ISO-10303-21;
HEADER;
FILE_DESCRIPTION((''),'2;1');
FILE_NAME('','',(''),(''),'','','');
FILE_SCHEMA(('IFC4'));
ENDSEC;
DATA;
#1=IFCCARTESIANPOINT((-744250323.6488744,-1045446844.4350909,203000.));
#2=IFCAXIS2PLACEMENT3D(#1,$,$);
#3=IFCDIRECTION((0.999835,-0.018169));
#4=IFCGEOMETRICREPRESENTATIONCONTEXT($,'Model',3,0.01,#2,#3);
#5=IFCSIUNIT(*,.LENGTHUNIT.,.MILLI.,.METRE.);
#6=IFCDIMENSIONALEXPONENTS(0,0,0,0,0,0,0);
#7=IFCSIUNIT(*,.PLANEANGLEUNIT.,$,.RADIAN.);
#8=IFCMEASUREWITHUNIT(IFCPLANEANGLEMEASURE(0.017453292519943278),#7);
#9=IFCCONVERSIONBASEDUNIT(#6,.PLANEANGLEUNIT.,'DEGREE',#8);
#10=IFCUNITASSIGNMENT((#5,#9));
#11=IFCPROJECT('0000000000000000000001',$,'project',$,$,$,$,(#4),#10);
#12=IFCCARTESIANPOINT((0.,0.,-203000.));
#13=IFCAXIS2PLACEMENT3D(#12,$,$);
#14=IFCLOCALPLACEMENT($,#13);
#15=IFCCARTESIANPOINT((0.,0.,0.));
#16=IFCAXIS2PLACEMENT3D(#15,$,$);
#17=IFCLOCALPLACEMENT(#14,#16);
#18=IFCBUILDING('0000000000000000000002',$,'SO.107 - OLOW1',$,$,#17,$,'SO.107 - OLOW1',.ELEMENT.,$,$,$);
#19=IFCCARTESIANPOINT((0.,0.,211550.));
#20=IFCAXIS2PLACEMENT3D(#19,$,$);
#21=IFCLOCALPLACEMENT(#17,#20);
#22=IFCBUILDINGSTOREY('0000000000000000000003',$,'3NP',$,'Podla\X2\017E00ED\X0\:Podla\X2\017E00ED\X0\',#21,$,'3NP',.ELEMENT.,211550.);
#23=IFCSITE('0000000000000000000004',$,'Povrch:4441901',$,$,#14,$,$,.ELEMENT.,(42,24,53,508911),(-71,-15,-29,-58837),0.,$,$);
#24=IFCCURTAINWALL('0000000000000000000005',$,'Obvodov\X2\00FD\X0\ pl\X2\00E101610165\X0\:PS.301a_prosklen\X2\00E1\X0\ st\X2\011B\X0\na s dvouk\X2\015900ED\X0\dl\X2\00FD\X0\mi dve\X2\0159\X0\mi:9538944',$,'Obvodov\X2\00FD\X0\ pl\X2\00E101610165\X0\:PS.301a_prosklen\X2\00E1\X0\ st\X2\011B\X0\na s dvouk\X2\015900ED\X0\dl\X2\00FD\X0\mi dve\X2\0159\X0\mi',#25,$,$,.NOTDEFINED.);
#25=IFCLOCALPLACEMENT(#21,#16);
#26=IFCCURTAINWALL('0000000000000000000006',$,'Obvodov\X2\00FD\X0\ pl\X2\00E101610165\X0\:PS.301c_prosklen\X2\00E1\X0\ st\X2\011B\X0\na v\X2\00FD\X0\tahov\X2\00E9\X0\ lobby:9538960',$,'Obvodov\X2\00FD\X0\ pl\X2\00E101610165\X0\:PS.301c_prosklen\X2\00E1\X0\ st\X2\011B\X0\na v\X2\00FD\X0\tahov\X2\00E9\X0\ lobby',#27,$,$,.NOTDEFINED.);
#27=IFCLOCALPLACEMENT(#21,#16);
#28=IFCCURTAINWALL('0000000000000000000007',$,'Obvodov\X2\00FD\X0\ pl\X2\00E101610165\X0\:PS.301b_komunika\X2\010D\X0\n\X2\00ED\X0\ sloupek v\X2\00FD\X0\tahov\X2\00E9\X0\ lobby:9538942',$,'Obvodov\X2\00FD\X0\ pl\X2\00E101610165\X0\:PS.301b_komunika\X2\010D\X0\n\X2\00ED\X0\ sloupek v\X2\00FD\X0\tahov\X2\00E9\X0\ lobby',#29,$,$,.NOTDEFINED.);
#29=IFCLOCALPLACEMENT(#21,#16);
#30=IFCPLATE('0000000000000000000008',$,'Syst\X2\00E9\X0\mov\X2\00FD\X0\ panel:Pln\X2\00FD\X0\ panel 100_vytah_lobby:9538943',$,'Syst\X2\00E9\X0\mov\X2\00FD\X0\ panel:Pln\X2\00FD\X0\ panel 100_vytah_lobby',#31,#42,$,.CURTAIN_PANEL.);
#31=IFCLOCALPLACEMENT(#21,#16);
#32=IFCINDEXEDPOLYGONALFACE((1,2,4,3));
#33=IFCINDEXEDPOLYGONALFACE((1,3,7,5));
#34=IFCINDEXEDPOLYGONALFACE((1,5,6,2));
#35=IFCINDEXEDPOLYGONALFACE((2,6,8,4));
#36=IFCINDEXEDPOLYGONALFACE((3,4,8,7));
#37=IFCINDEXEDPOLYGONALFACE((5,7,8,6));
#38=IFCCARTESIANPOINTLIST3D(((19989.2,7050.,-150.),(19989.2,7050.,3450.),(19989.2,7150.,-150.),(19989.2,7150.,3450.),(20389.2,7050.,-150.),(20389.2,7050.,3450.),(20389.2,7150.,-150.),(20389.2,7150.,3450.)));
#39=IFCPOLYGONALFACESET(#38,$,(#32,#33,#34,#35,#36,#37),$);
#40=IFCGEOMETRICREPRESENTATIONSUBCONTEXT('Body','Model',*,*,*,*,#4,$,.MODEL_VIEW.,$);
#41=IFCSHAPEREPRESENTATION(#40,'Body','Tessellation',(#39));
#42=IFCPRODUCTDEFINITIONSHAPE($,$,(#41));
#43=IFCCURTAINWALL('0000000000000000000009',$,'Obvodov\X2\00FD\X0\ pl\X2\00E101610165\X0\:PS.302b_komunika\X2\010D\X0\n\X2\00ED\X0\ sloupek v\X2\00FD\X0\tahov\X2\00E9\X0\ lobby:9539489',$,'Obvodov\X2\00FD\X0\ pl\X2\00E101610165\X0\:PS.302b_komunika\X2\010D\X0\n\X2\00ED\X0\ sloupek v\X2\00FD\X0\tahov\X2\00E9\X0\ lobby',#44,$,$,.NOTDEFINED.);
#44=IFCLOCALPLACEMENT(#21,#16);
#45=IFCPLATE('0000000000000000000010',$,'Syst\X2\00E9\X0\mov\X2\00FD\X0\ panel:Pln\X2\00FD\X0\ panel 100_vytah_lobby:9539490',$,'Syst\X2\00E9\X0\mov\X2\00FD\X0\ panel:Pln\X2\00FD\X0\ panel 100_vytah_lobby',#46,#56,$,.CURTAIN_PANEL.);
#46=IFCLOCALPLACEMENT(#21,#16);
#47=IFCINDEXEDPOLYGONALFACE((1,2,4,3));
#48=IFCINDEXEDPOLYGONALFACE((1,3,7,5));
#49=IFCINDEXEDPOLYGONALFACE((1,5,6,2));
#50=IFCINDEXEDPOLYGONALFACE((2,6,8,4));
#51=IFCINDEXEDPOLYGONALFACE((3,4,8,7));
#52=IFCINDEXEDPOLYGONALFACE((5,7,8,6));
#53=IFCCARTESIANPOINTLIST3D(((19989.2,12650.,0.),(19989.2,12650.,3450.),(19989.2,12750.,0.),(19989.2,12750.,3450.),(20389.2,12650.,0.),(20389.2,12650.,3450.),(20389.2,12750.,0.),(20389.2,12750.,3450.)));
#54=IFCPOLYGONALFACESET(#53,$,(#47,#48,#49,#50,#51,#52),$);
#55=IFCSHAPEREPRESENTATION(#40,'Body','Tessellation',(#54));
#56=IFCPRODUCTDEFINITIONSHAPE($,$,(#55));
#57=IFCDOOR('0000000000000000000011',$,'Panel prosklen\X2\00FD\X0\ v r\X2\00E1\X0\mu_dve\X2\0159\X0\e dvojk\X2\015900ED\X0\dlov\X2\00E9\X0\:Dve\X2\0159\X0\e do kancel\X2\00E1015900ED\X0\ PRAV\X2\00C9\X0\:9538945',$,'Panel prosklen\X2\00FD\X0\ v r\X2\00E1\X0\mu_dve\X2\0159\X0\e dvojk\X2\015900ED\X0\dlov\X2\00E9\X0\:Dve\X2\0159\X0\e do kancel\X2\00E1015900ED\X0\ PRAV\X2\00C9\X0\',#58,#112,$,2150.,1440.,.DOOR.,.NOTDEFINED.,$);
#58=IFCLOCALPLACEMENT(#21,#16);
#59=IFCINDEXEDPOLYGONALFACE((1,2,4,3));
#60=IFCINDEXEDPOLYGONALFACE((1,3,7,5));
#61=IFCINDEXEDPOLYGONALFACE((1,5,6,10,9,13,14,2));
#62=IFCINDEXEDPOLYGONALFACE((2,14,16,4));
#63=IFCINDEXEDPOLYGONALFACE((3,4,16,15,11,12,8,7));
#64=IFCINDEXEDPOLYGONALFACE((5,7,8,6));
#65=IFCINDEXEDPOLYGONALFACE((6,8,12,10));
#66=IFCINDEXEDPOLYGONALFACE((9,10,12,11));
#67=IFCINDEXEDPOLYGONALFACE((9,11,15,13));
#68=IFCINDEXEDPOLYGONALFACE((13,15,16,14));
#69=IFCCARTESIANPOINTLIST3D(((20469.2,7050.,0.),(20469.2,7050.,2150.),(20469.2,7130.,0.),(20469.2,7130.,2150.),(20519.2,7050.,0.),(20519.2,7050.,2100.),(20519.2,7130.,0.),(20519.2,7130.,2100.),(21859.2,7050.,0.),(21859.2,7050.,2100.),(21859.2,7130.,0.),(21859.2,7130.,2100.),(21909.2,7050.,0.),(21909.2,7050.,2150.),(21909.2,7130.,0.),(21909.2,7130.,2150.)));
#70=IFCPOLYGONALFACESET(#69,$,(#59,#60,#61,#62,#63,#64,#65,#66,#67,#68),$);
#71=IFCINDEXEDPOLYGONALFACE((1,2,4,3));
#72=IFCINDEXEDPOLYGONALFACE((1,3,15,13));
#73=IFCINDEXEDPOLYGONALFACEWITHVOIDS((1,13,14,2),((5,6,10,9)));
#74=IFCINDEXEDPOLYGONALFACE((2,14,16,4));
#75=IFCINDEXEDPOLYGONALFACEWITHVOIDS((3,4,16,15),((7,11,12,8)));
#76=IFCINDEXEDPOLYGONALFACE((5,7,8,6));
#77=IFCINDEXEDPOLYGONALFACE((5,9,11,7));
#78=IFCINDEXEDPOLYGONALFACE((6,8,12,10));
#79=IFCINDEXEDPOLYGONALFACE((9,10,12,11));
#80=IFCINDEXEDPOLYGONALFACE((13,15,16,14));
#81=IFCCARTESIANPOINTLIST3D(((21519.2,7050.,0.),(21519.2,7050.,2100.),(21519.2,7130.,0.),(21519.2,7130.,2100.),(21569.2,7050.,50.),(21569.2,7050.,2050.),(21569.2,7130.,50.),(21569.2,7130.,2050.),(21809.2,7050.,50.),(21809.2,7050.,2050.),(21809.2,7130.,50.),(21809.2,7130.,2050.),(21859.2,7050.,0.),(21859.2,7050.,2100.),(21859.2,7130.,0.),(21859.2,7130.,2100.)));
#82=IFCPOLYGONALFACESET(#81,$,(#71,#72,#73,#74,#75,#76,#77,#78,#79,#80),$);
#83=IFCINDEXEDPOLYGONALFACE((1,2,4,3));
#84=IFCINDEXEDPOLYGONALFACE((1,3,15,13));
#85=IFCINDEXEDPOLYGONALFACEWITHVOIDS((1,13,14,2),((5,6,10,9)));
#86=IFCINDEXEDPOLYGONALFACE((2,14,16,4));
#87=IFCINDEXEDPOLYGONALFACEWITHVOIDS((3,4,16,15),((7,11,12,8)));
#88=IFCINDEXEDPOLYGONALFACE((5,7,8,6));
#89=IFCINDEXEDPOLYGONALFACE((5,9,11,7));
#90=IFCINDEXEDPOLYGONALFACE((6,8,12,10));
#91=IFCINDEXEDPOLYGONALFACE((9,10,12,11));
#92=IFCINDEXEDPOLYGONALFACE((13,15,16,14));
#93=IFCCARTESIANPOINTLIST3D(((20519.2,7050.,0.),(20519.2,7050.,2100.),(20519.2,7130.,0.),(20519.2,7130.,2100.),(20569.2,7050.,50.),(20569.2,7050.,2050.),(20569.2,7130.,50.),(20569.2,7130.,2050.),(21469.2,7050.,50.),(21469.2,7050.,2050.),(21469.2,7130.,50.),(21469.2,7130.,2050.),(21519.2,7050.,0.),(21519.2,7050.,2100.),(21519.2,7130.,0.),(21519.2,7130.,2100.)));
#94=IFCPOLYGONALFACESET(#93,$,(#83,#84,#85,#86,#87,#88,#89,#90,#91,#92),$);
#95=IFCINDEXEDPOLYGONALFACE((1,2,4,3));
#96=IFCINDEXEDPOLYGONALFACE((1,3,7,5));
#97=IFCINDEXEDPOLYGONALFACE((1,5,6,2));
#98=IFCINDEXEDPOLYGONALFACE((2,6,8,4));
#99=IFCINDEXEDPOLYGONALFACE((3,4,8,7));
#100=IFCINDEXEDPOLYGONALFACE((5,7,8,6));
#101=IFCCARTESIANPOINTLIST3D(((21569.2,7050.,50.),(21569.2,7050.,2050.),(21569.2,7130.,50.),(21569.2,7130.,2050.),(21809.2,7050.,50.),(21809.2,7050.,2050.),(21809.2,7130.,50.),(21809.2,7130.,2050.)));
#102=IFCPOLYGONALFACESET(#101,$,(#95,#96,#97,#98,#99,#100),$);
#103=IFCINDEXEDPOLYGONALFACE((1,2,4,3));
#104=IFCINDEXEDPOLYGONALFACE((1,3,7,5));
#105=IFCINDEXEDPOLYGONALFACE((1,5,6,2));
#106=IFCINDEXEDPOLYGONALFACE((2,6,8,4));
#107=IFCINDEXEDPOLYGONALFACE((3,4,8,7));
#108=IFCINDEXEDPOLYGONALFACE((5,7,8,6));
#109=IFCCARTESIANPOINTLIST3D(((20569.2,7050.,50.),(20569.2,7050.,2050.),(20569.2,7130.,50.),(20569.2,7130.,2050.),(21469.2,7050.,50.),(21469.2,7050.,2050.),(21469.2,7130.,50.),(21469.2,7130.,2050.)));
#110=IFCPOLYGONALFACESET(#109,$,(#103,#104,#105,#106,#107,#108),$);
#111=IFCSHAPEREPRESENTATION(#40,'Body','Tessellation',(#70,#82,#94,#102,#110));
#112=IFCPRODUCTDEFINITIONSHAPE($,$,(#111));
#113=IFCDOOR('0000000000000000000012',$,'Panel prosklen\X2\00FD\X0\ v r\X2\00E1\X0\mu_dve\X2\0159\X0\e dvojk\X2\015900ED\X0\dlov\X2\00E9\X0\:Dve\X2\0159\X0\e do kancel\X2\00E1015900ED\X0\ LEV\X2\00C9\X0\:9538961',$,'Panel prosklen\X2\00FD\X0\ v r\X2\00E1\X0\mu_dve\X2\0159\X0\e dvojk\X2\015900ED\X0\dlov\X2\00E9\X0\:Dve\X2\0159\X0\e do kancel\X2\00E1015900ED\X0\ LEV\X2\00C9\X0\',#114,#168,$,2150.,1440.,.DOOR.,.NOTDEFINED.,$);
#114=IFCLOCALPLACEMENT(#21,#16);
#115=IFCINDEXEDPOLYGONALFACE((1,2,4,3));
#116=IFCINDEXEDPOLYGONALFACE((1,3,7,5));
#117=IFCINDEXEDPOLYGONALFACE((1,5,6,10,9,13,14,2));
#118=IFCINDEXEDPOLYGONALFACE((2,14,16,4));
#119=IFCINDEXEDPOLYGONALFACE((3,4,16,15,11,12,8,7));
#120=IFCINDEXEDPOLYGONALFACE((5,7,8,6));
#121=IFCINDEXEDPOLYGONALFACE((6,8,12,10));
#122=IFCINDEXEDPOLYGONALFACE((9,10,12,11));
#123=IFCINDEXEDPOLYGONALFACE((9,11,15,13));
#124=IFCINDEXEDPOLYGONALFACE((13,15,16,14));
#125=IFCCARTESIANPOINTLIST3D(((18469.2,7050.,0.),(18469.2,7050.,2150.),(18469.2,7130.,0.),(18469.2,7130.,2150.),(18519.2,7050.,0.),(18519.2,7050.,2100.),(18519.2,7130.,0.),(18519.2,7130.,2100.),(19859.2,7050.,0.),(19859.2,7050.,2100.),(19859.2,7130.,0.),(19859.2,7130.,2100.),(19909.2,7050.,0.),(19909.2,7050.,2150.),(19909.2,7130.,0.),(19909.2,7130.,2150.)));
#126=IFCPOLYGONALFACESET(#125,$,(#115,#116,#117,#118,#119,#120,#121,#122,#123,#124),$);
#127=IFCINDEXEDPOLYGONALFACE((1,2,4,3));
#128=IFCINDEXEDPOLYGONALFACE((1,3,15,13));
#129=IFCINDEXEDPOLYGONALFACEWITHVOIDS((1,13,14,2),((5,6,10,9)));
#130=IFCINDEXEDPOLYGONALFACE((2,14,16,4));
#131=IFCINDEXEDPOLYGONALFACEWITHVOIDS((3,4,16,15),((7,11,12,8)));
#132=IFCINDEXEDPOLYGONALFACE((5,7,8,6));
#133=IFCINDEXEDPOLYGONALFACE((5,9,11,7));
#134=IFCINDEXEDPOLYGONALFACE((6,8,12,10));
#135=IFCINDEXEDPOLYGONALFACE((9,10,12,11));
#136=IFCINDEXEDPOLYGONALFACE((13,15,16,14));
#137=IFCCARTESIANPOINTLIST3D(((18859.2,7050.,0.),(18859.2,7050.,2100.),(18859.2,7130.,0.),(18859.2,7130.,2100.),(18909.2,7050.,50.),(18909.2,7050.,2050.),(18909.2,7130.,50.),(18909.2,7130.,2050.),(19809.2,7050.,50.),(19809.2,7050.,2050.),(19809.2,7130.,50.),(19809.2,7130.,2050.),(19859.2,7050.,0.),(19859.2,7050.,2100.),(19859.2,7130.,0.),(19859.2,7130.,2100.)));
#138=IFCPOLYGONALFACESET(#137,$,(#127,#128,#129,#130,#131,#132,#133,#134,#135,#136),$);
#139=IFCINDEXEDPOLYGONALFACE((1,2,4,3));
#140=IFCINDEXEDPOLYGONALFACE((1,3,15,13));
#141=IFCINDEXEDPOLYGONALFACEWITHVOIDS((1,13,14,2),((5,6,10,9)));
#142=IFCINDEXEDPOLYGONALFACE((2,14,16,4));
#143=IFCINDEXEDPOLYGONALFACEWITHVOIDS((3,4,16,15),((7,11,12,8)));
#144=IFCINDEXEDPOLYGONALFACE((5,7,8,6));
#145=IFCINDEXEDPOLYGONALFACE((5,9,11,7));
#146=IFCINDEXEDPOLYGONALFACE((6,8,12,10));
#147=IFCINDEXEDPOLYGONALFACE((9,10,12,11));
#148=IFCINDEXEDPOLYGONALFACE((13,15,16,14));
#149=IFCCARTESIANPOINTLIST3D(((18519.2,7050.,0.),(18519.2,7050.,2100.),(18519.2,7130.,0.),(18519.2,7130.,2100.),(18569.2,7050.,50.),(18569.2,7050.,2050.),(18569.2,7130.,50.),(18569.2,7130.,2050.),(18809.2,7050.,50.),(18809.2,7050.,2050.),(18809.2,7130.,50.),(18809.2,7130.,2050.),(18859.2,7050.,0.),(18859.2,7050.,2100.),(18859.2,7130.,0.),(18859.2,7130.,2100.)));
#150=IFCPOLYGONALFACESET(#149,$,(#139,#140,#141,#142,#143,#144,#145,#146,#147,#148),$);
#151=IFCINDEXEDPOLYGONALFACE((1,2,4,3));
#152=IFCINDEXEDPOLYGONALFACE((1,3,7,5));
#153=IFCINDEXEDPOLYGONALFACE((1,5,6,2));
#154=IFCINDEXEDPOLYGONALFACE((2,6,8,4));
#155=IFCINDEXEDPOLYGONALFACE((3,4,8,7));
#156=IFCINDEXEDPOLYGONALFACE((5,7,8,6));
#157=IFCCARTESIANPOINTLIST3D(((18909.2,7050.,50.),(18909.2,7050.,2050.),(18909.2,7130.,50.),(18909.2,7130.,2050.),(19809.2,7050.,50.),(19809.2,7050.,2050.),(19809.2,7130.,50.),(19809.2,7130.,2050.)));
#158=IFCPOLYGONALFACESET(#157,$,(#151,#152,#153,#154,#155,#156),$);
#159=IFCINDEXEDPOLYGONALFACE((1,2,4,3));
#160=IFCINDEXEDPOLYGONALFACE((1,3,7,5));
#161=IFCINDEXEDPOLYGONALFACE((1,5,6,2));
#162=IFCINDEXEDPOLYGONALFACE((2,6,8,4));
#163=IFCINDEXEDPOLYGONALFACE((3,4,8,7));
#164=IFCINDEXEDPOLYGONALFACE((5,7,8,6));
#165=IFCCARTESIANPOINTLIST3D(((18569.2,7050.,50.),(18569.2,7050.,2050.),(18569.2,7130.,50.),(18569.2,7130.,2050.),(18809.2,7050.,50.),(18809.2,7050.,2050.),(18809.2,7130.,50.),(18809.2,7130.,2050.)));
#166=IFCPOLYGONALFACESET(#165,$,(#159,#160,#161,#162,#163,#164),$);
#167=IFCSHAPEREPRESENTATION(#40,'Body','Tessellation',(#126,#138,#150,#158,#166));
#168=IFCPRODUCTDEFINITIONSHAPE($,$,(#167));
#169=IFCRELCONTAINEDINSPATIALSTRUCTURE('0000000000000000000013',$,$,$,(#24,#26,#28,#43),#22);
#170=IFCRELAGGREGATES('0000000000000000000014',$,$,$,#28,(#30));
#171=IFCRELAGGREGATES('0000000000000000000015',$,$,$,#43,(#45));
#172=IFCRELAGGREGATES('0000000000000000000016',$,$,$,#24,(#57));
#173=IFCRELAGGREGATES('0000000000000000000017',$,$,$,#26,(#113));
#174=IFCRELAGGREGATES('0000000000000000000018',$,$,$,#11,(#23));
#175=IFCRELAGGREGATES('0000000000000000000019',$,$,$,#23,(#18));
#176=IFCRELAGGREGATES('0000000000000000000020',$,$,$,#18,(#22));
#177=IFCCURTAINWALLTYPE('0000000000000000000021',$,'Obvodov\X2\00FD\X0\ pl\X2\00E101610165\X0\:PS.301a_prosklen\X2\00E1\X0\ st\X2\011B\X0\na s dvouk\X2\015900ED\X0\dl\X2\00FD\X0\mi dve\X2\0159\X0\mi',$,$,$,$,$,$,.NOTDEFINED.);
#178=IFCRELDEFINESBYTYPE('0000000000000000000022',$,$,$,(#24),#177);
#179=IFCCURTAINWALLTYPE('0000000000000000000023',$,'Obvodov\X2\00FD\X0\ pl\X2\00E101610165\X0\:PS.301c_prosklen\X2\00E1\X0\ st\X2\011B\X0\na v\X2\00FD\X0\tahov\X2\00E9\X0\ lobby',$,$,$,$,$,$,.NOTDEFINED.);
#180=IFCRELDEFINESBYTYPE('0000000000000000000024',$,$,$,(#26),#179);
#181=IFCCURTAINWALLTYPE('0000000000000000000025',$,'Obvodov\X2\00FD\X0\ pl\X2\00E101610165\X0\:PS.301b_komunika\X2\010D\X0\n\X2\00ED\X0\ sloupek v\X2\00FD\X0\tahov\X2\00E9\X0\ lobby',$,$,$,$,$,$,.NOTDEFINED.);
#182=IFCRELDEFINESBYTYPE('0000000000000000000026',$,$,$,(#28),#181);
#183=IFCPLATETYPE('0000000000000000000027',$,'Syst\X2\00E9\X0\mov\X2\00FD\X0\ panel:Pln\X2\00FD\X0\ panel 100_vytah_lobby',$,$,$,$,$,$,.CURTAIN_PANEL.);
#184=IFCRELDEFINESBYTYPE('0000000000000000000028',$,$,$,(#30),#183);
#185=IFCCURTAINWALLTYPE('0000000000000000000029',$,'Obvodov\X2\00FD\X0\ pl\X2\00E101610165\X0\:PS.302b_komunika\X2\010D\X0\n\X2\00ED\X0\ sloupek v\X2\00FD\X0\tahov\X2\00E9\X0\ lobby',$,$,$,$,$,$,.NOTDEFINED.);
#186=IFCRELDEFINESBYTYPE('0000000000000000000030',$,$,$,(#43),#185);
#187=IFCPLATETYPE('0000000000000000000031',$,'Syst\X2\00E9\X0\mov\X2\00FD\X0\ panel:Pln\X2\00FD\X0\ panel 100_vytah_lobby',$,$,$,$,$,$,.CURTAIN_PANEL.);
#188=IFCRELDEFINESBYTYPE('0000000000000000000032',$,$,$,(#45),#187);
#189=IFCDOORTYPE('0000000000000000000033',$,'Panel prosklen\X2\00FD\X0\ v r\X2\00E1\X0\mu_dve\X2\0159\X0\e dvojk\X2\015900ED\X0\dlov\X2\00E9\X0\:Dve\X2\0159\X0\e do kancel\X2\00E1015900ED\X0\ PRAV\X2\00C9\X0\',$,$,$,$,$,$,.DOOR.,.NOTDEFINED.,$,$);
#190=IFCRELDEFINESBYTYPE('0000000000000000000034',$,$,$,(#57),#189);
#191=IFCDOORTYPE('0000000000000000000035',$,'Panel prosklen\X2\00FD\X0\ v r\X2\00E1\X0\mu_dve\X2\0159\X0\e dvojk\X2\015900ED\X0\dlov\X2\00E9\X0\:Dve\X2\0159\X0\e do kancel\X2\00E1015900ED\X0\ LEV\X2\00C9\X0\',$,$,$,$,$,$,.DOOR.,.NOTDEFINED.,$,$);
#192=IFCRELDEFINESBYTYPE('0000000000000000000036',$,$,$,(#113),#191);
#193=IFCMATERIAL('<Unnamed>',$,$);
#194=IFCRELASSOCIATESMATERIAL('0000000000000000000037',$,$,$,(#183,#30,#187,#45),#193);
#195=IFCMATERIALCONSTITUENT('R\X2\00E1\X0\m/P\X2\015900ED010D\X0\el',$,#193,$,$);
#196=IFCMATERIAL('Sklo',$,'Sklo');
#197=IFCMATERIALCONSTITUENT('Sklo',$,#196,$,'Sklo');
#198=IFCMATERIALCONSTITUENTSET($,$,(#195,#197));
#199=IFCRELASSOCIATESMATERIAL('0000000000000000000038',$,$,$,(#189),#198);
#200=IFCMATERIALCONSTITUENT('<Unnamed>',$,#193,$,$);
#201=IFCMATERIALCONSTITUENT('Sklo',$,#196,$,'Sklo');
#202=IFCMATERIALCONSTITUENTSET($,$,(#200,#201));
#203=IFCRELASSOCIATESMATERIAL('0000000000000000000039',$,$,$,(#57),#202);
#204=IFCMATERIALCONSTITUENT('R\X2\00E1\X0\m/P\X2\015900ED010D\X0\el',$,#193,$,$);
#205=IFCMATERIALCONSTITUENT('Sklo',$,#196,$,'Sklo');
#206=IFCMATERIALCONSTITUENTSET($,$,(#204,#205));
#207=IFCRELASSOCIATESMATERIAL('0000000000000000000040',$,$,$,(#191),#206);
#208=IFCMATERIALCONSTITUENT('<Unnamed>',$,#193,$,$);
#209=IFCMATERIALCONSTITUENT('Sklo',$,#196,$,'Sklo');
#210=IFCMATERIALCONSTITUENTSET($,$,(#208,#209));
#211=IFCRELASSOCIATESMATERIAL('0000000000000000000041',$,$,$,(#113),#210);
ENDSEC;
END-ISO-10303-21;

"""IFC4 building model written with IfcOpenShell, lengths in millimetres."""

from ifc_helpers import new_model, entity, si_unit, converted_unit, direction, frame, origin, place, context, subcontext, project, spatial, indexed_curve, outline, extrude, source, transform, mapped, material, constituent, constituent_set, type_object, type_shapes, element, aggregate, save


model = new_model("IFC4")

# Units and contexts
model_context = context("Model", 3, precision=0.01, world=frame((-744250323.6488744, -1045446844.4350909, 203000.0)), true_north=direction((0.999835, -0.018169)))
body_context = subcontext(model_context, "Body", "Model", "MODEL_VIEW")
ifc_project = project(units=[si_unit("LENGTHUNIT", "METRE", prefix="MILLI"), converted_unit("PLANEANGLEUNIT", "DEGREE", entity("IfcPlaneAngleMeasure", 0.017453292519943278), si_unit("PLANEANGLEUNIT", "RADIAN"), dimensions=[0, 0, 0, 0, 0, 0, 0])], contexts=[model_context])

# Site, building, storey
site_placement = place(None, frame((0.0, 0.0, -203000.0)))
site = spatial("IfcSite", under=ifc_project, at=site_placement, Name="Povrch:4441901", CompositionType="ELEMENT", RefLatitude=(42, 24, 53, 508911), RefLongitude=(-71, -15, -29, -58837), RefElevation=0.0)
building_placement = place(site_placement, origin())
building = spatial("IfcBuilding", under=site, at=building_placement, Name="SO.107 - OLOW1", LongName="SO.107 - OLOW1", CompositionType="ELEMENT")
storey_placement = place(building_placement, frame((0.0, 0.0, 211550.0)))
storey = spatial("IfcBuildingStorey", under=building, at=storey_placement, Name="3NP", ObjectType="Podlaží:Podlaží", LongName="3NP", CompositionType="ELEMENT", Elevation=211550.0)

# Curtain walls
curtain_wall_type_1 = type_object("IfcCurtainWallType", Name="Obvodový plášť:PS.301a_prosklená stěna s dvoukřídlými dveřmi", PredefinedType="NOTDEFINED")
curtain_wall_1_placement = place(storey_placement, frame((0.0, 0.0, -211550.0)))
curtain_wall_1 = element("IfcCurtainWall", 1, at=curtain_wall_1_placement, inside=storey, type_object=curtain_wall_type_1, Name="Obvodový plášť:PS.301a_prosklená stěna s dvoukřídlými dveřmi:9538944", ObjectType="Obvodový plášť:PS.301a_prosklená stěna s dvoukřídlými dveřmi", PredefinedType="NOTDEFINED")
ifc_material_1 = material(Name="<Unnamed>")
curtain_wall_type_2 = type_object("IfcCurtainWallType", Name="Obvodový plášť:PS.301c_prosklená stěna výtahové lobby", PredefinedType="NOTDEFINED")
curtain_wall_2_placement = place(storey_placement, frame((0.0, 0.0, -211550.0)))
curtain_wall_2 = element("IfcCurtainWall", 2, at=curtain_wall_2_placement, inside=storey, type_object=curtain_wall_type_2, Name="Obvodový plášť:PS.301c_prosklená stěna výtahové lobby:9538960", ObjectType="Obvodový plášť:PS.301c_prosklená stěna výtahové lobby", PredefinedType="NOTDEFINED")

# Shared definitions
ifc_material_2 = material(Name="Sklo", Category="Sklo")

# Curtain walls, plates
curtain_wall_type_3 = type_object("IfcCurtainWallType", Name="Obvodový plášť:PS.301b_komunikační sloupek výtahové lobby", PredefinedType="NOTDEFINED")
curtain_wall_3_placement = place(storey_placement, frame((0.0, 0.0, -211550.0)))
curtain_wall_3 = element("IfcCurtainWall", 3, at=curtain_wall_3_placement, inside=storey, type_object=curtain_wall_type_3, Name="Obvodový plášť:PS.301b_komunikační sloupek výtahové lobby:9538942", ObjectType="Obvodový plášť:PS.301b_komunikační sloupek výtahové lobby", PredefinedType="NOTDEFINED")
plate_type_1 = type_object("IfcPlateType", Name="Systémový panel:Plný panel 100_vytah_lobby", PredefinedType="CURTAIN_PANEL", material=ifc_material_1)
shared_shape_1 = source(origin(), body_context, "Body", "SweptSolid", [
    extrude(outline(indexed_curve([(-50.0, -200.0), (50.0, -200.0), (50.0, 200.0), (-50.0, 200.0), (-50.0, -200.0)], self_intersect=False)), frame((0.0, 10.0, 0.0), z_axis=(0.0, 0.0, 1.0), x_axis=(0.0, 1.0, 0.0)), (0.0, 0.0, 1.0), 3600.0),
])
type_shapes(plate_type_1, [shared_shape_1])
plate_1_placement = place(curtain_wall_3_placement, frame((20189.2, 7090.0, 211400.0)))
plate_1 = element("IfcPlate", 4, at=plate_1_placement, type_object=plate_type_1, material=ifc_material_1, Name="Systémový panel:Plný panel 100_vytah_lobby:9538943", ObjectType="Systémový panel:Plný panel 100_vytah_lobby", PredefinedType="CURTAIN_PANEL", context=body_context, shape_type="MappedRepresentation", body=[
    mapped(shared_shape_1, transform((0.0, 0.0, 0.0), scale=1.0)),
])
aggregate(curtain_wall_3, [plate_1])
curtain_wall_type_4 = type_object("IfcCurtainWallType", Name="Obvodový plášť:PS.302b_komunikační sloupek výtahové lobby", PredefinedType="NOTDEFINED")
curtain_wall_4_placement = place(storey_placement, frame((0.0, 0.0, -211550.0)))
curtain_wall_4 = element("IfcCurtainWall", 5, at=curtain_wall_4_placement, inside=storey, type_object=curtain_wall_type_4, Name="Obvodový plášť:PS.302b_komunikační sloupek výtahové lobby:9539489", ObjectType="Obvodový plášť:PS.302b_komunikační sloupek výtahové lobby", PredefinedType="NOTDEFINED")
plate_type_2 = type_object("IfcPlateType", Name="Systémový panel:Plný panel 100_vytah_lobby", PredefinedType="CURTAIN_PANEL", material=ifc_material_1)
shared_shape_2 = source(origin(), body_context, "Body", "SweptSolid", [
    extrude(outline(indexed_curve([(-50.0, -200.0), (50.0, -200.0), (50.0, 200.0), (-50.0, 200.0), (-50.0, -200.0)], self_intersect=False)), frame((0.0, 10.0, 0.0), z_axis=(0.0, 0.0, 1.0), x_axis=(0.0, 1.0, 0.0)), (0.0, 0.0, 1.0), 3450.0),
])
type_shapes(plate_type_2, [shared_shape_2])
plate_2_placement = place(curtain_wall_4_placement, frame((20189.2, 12690.0, 211550.0)))
plate_2 = element("IfcPlate", 6, at=plate_2_placement, type_object=plate_type_2, material=ifc_material_1, Name="Systémový panel:Plný panel 100_vytah_lobby:9539490", ObjectType="Systémový panel:Plný panel 100_vytah_lobby", PredefinedType="CURTAIN_PANEL", context=body_context, shape_type="MappedRepresentation", body=[
    mapped(shared_shape_2, transform((0.0, 0.0, 0.0), scale=1.0)),
])
aggregate(curtain_wall_4, [plate_2])

# Doors
ifc_constituent_1 = constituent(ifc_material_1, Name="<Unnamed>")
ifc_constituent_2 = constituent(ifc_material_2, Name="Sklo", Category="Sklo")
ifc_constituent_set_1 = constituent_set(constituents=[ifc_constituent_1, ifc_constituent_2])
ifc_constituent_3 = constituent(ifc_material_1, Name="Rám/Příčel")
ifc_constituent_4 = constituent(ifc_material_2, Name="Sklo", Category="Sklo")
ifc_constituent_set_2 = constituent_set(constituents=[ifc_constituent_3, ifc_constituent_4])
door_type_1 = type_object("IfcDoorType", Name="Panel prosklený v rámu_dveře dvojkřídlové:Dveře do kanceláří PRAVÉ", OperationType="NOTDEFINED", PredefinedType="DOOR", material=ifc_constituent_set_2)
shared_shape_3 = source(origin(), body_context, "Body", "SweptSolid", [
    extrude(outline(indexed_curve([(-720.0, -1087.5), (720.0, -1087.5), (720.0, 1062.5), (670.0, 1062.5), (670.0, -1037.5), (-670.0, -1037.5), (-670.0, 1062.5), (-720.0, 1062.5), (-720.0, -1087.5)], self_intersect=False)), frame((0.0, 40.0, 1062.5), z_axis=(0.0, -1.0, 0.0), x_axis=(-1.0, 0.0, 0.0)), (0.0, 0.0, 1.0), 80.0),
    extrude(outline(indexed_curve([(-1050.0, -170.0), (1050.0, -170.0), (1050.0, 170.0), (-1050.0, 170.0), (-1050.0, -170.0)], self_intersect=False), holes=[indexed_curve([(-1000.0, -120.0), (-1000.0, 120.0), (1000.0, 120.0), (1000.0, -120.0), (-1000.0, -120.0)], self_intersect=False)]), frame((-500.0, 40.0, 1050.0), z_axis=(0.0, -1.0, 0.0), x_axis=(0.0, 0.0, -1.0)), (0.0, 0.0, 1.0), 80.0),
    extrude(outline(indexed_curve([(-1050.0, -500.0), (1050.0, -500.0), (1050.0, 500.0), (-1050.0, 500.0), (-1050.0, -500.0)], self_intersect=False), holes=[indexed_curve([(-1000.0, -450.0), (-1000.0, 450.0), (1000.0, 450.0), (1000.0, -450.0), (-1000.0, -450.0)], self_intersect=False)]), frame((170.0, 40.0, 1050.0), z_axis=(0.0, -1.0, 0.0), x_axis=(0.0, 0.0, -1.0)), (0.0, 0.0, 1.0), 80.0),
    extrude(outline(indexed_curve([(-120.0, -40.0), (120.0, -40.0), (120.0, 40.0), (-120.0, 40.0), (-120.0, -40.0)], self_intersect=False)), frame((-500.0, 0.0, 50.0)), (0.0, 0.0, 1.0), 2000.0),
    extrude(outline(indexed_curve([(-450.0, -40.0), (450.0, -40.0), (450.0, 40.0), (-450.0, 40.0), (-450.0, -40.0)], self_intersect=False)), frame((170.0, 0.0, 50.0)), (0.0, 0.0, 1.0), 2000.0),
])
type_shapes(door_type_1, [shared_shape_3])
door_1_placement = place(curtain_wall_1_placement, frame((21189.2, 7090.0, 211550.0), z_axis=(0.0, 0.0, 1.0), x_axis=(-1.0, 0.0, 0.0)))
door_1 = element("IfcDoor", 7, at=door_1_placement, type_object=door_type_1, material=ifc_constituent_set_1, Name="Panel prosklený v rámu_dveře dvojkřídlové:Dveře do kanceláří PRAVÉ:9538945", ObjectType="Panel prosklený v rámu_dveře dvojkřídlové:Dveře do kanceláří PRAVÉ", OperationType="NOTDEFINED", OverallHeight=2150.0, OverallWidth=1440.0, PredefinedType="DOOR", context=body_context, shape_type="MappedRepresentation", body=[
    mapped(shared_shape_3, transform((0.0, 0.0, 0.0), scale=1.0)),
])
aggregate(curtain_wall_1, [door_1])
ifc_constituent_5 = constituent(ifc_material_1, Name="<Unnamed>")
ifc_constituent_6 = constituent(ifc_material_2, Name="Sklo", Category="Sklo")
ifc_constituent_set_3 = constituent_set(constituents=[ifc_constituent_5, ifc_constituent_6])
ifc_constituent_7 = constituent(ifc_material_1, Name="Rám/Příčel")
ifc_constituent_8 = constituent(ifc_material_2, Name="Sklo", Category="Sklo")
ifc_constituent_set_4 = constituent_set(constituents=[ifc_constituent_7, ifc_constituent_8])
door_type_2 = type_object("IfcDoorType", Name="Panel prosklený v rámu_dveře dvojkřídlové:Dveře do kanceláří LEVÉ", OperationType="NOTDEFINED", PredefinedType="DOOR", material=ifc_constituent_set_4)
shared_shape_4 = source(origin(), body_context, "Body", "SweptSolid", [
    extrude(outline(indexed_curve([(-720.0, -1087.5), (720.0, -1087.5), (720.0, 1062.5), (670.0, 1062.5), (670.0, -1037.5), (-670.0, -1037.5), (-670.0, 1062.5), (-720.0, 1062.5), (-720.0, -1087.5)], self_intersect=False)), frame((0.0, 40.0, 1062.5), z_axis=(0.0, -1.0, 0.0), x_axis=(-1.0, 0.0, 0.0)), (0.0, 0.0, 1.0), 80.0),
    extrude(outline(indexed_curve([(-1050.0, -500.0), (1050.0, -500.0), (1050.0, 500.0), (-1050.0, 500.0), (-1050.0, -500.0)], self_intersect=False), holes=[indexed_curve([(-1000.0, -450.0), (-1000.0, 450.0), (1000.0, 450.0), (1000.0, -450.0), (-1000.0, -450.0)], self_intersect=False)]), frame((-170.0, 40.0, 1050.0), z_axis=(0.0, -1.0, 0.0), x_axis=(0.0, 0.0, -1.0)), (0.0, 0.0, 1.0), 80.0),
    extrude(outline(indexed_curve([(-1050.0, -170.0), (1050.0, -170.0), (1050.0, 170.0), (-1050.0, 170.0), (-1050.0, -170.0)], self_intersect=False), holes=[indexed_curve([(-1000.0, -120.0), (-1000.0, 120.0), (1000.0, 120.0), (1000.0, -120.0), (-1000.0, -120.0)], self_intersect=False)]), frame((500.0, 40.0, 1050.0), z_axis=(0.0, -1.0, 0.0), x_axis=(0.0, 0.0, -1.0)), (0.0, 0.0, 1.0), 80.0),
    extrude(outline(indexed_curve([(-450.0, -40.0), (450.0, -40.0), (450.0, 40.0), (-450.0, 40.0), (-450.0, -40.0)], self_intersect=False)), frame((-170.0, 0.0, 50.0)), (0.0, 0.0, 1.0), 2000.0),
    extrude(outline(indexed_curve([(-120.0, -40.0), (120.0, -40.0), (120.0, 40.0), (-120.0, 40.0), (-120.0, -40.0)], self_intersect=False)), frame((500.0, 0.0, 50.0)), (0.0, 0.0, 1.0), 2000.0),
])
type_shapes(door_type_2, [shared_shape_4])
door_2_placement = place(curtain_wall_2_placement, frame((19189.2, 7090.0, 211550.0), z_axis=(0.0, 0.0, 1.0), x_axis=(-1.0, 0.0, 0.0)))
door_2 = element("IfcDoor", 8, at=door_2_placement, type_object=door_type_2, material=ifc_constituent_set_3, Name="Panel prosklený v rámu_dveře dvojkřídlové:Dveře do kanceláří LEVÉ:9538961", ObjectType="Panel prosklený v rámu_dveře dvojkřídlové:Dveře do kanceláří LEVÉ", OperationType="NOTDEFINED", OverallHeight=2150.0, OverallWidth=1440.0, PredefinedType="DOOR", context=body_context, shape_type="MappedRepresentation", body=[
    mapped(shared_shape_4, transform((0.0, 0.0, 0.0), scale=1.0)),
])
aggregate(curtain_wall_2, [door_2])

save(model, "model.ifc")
